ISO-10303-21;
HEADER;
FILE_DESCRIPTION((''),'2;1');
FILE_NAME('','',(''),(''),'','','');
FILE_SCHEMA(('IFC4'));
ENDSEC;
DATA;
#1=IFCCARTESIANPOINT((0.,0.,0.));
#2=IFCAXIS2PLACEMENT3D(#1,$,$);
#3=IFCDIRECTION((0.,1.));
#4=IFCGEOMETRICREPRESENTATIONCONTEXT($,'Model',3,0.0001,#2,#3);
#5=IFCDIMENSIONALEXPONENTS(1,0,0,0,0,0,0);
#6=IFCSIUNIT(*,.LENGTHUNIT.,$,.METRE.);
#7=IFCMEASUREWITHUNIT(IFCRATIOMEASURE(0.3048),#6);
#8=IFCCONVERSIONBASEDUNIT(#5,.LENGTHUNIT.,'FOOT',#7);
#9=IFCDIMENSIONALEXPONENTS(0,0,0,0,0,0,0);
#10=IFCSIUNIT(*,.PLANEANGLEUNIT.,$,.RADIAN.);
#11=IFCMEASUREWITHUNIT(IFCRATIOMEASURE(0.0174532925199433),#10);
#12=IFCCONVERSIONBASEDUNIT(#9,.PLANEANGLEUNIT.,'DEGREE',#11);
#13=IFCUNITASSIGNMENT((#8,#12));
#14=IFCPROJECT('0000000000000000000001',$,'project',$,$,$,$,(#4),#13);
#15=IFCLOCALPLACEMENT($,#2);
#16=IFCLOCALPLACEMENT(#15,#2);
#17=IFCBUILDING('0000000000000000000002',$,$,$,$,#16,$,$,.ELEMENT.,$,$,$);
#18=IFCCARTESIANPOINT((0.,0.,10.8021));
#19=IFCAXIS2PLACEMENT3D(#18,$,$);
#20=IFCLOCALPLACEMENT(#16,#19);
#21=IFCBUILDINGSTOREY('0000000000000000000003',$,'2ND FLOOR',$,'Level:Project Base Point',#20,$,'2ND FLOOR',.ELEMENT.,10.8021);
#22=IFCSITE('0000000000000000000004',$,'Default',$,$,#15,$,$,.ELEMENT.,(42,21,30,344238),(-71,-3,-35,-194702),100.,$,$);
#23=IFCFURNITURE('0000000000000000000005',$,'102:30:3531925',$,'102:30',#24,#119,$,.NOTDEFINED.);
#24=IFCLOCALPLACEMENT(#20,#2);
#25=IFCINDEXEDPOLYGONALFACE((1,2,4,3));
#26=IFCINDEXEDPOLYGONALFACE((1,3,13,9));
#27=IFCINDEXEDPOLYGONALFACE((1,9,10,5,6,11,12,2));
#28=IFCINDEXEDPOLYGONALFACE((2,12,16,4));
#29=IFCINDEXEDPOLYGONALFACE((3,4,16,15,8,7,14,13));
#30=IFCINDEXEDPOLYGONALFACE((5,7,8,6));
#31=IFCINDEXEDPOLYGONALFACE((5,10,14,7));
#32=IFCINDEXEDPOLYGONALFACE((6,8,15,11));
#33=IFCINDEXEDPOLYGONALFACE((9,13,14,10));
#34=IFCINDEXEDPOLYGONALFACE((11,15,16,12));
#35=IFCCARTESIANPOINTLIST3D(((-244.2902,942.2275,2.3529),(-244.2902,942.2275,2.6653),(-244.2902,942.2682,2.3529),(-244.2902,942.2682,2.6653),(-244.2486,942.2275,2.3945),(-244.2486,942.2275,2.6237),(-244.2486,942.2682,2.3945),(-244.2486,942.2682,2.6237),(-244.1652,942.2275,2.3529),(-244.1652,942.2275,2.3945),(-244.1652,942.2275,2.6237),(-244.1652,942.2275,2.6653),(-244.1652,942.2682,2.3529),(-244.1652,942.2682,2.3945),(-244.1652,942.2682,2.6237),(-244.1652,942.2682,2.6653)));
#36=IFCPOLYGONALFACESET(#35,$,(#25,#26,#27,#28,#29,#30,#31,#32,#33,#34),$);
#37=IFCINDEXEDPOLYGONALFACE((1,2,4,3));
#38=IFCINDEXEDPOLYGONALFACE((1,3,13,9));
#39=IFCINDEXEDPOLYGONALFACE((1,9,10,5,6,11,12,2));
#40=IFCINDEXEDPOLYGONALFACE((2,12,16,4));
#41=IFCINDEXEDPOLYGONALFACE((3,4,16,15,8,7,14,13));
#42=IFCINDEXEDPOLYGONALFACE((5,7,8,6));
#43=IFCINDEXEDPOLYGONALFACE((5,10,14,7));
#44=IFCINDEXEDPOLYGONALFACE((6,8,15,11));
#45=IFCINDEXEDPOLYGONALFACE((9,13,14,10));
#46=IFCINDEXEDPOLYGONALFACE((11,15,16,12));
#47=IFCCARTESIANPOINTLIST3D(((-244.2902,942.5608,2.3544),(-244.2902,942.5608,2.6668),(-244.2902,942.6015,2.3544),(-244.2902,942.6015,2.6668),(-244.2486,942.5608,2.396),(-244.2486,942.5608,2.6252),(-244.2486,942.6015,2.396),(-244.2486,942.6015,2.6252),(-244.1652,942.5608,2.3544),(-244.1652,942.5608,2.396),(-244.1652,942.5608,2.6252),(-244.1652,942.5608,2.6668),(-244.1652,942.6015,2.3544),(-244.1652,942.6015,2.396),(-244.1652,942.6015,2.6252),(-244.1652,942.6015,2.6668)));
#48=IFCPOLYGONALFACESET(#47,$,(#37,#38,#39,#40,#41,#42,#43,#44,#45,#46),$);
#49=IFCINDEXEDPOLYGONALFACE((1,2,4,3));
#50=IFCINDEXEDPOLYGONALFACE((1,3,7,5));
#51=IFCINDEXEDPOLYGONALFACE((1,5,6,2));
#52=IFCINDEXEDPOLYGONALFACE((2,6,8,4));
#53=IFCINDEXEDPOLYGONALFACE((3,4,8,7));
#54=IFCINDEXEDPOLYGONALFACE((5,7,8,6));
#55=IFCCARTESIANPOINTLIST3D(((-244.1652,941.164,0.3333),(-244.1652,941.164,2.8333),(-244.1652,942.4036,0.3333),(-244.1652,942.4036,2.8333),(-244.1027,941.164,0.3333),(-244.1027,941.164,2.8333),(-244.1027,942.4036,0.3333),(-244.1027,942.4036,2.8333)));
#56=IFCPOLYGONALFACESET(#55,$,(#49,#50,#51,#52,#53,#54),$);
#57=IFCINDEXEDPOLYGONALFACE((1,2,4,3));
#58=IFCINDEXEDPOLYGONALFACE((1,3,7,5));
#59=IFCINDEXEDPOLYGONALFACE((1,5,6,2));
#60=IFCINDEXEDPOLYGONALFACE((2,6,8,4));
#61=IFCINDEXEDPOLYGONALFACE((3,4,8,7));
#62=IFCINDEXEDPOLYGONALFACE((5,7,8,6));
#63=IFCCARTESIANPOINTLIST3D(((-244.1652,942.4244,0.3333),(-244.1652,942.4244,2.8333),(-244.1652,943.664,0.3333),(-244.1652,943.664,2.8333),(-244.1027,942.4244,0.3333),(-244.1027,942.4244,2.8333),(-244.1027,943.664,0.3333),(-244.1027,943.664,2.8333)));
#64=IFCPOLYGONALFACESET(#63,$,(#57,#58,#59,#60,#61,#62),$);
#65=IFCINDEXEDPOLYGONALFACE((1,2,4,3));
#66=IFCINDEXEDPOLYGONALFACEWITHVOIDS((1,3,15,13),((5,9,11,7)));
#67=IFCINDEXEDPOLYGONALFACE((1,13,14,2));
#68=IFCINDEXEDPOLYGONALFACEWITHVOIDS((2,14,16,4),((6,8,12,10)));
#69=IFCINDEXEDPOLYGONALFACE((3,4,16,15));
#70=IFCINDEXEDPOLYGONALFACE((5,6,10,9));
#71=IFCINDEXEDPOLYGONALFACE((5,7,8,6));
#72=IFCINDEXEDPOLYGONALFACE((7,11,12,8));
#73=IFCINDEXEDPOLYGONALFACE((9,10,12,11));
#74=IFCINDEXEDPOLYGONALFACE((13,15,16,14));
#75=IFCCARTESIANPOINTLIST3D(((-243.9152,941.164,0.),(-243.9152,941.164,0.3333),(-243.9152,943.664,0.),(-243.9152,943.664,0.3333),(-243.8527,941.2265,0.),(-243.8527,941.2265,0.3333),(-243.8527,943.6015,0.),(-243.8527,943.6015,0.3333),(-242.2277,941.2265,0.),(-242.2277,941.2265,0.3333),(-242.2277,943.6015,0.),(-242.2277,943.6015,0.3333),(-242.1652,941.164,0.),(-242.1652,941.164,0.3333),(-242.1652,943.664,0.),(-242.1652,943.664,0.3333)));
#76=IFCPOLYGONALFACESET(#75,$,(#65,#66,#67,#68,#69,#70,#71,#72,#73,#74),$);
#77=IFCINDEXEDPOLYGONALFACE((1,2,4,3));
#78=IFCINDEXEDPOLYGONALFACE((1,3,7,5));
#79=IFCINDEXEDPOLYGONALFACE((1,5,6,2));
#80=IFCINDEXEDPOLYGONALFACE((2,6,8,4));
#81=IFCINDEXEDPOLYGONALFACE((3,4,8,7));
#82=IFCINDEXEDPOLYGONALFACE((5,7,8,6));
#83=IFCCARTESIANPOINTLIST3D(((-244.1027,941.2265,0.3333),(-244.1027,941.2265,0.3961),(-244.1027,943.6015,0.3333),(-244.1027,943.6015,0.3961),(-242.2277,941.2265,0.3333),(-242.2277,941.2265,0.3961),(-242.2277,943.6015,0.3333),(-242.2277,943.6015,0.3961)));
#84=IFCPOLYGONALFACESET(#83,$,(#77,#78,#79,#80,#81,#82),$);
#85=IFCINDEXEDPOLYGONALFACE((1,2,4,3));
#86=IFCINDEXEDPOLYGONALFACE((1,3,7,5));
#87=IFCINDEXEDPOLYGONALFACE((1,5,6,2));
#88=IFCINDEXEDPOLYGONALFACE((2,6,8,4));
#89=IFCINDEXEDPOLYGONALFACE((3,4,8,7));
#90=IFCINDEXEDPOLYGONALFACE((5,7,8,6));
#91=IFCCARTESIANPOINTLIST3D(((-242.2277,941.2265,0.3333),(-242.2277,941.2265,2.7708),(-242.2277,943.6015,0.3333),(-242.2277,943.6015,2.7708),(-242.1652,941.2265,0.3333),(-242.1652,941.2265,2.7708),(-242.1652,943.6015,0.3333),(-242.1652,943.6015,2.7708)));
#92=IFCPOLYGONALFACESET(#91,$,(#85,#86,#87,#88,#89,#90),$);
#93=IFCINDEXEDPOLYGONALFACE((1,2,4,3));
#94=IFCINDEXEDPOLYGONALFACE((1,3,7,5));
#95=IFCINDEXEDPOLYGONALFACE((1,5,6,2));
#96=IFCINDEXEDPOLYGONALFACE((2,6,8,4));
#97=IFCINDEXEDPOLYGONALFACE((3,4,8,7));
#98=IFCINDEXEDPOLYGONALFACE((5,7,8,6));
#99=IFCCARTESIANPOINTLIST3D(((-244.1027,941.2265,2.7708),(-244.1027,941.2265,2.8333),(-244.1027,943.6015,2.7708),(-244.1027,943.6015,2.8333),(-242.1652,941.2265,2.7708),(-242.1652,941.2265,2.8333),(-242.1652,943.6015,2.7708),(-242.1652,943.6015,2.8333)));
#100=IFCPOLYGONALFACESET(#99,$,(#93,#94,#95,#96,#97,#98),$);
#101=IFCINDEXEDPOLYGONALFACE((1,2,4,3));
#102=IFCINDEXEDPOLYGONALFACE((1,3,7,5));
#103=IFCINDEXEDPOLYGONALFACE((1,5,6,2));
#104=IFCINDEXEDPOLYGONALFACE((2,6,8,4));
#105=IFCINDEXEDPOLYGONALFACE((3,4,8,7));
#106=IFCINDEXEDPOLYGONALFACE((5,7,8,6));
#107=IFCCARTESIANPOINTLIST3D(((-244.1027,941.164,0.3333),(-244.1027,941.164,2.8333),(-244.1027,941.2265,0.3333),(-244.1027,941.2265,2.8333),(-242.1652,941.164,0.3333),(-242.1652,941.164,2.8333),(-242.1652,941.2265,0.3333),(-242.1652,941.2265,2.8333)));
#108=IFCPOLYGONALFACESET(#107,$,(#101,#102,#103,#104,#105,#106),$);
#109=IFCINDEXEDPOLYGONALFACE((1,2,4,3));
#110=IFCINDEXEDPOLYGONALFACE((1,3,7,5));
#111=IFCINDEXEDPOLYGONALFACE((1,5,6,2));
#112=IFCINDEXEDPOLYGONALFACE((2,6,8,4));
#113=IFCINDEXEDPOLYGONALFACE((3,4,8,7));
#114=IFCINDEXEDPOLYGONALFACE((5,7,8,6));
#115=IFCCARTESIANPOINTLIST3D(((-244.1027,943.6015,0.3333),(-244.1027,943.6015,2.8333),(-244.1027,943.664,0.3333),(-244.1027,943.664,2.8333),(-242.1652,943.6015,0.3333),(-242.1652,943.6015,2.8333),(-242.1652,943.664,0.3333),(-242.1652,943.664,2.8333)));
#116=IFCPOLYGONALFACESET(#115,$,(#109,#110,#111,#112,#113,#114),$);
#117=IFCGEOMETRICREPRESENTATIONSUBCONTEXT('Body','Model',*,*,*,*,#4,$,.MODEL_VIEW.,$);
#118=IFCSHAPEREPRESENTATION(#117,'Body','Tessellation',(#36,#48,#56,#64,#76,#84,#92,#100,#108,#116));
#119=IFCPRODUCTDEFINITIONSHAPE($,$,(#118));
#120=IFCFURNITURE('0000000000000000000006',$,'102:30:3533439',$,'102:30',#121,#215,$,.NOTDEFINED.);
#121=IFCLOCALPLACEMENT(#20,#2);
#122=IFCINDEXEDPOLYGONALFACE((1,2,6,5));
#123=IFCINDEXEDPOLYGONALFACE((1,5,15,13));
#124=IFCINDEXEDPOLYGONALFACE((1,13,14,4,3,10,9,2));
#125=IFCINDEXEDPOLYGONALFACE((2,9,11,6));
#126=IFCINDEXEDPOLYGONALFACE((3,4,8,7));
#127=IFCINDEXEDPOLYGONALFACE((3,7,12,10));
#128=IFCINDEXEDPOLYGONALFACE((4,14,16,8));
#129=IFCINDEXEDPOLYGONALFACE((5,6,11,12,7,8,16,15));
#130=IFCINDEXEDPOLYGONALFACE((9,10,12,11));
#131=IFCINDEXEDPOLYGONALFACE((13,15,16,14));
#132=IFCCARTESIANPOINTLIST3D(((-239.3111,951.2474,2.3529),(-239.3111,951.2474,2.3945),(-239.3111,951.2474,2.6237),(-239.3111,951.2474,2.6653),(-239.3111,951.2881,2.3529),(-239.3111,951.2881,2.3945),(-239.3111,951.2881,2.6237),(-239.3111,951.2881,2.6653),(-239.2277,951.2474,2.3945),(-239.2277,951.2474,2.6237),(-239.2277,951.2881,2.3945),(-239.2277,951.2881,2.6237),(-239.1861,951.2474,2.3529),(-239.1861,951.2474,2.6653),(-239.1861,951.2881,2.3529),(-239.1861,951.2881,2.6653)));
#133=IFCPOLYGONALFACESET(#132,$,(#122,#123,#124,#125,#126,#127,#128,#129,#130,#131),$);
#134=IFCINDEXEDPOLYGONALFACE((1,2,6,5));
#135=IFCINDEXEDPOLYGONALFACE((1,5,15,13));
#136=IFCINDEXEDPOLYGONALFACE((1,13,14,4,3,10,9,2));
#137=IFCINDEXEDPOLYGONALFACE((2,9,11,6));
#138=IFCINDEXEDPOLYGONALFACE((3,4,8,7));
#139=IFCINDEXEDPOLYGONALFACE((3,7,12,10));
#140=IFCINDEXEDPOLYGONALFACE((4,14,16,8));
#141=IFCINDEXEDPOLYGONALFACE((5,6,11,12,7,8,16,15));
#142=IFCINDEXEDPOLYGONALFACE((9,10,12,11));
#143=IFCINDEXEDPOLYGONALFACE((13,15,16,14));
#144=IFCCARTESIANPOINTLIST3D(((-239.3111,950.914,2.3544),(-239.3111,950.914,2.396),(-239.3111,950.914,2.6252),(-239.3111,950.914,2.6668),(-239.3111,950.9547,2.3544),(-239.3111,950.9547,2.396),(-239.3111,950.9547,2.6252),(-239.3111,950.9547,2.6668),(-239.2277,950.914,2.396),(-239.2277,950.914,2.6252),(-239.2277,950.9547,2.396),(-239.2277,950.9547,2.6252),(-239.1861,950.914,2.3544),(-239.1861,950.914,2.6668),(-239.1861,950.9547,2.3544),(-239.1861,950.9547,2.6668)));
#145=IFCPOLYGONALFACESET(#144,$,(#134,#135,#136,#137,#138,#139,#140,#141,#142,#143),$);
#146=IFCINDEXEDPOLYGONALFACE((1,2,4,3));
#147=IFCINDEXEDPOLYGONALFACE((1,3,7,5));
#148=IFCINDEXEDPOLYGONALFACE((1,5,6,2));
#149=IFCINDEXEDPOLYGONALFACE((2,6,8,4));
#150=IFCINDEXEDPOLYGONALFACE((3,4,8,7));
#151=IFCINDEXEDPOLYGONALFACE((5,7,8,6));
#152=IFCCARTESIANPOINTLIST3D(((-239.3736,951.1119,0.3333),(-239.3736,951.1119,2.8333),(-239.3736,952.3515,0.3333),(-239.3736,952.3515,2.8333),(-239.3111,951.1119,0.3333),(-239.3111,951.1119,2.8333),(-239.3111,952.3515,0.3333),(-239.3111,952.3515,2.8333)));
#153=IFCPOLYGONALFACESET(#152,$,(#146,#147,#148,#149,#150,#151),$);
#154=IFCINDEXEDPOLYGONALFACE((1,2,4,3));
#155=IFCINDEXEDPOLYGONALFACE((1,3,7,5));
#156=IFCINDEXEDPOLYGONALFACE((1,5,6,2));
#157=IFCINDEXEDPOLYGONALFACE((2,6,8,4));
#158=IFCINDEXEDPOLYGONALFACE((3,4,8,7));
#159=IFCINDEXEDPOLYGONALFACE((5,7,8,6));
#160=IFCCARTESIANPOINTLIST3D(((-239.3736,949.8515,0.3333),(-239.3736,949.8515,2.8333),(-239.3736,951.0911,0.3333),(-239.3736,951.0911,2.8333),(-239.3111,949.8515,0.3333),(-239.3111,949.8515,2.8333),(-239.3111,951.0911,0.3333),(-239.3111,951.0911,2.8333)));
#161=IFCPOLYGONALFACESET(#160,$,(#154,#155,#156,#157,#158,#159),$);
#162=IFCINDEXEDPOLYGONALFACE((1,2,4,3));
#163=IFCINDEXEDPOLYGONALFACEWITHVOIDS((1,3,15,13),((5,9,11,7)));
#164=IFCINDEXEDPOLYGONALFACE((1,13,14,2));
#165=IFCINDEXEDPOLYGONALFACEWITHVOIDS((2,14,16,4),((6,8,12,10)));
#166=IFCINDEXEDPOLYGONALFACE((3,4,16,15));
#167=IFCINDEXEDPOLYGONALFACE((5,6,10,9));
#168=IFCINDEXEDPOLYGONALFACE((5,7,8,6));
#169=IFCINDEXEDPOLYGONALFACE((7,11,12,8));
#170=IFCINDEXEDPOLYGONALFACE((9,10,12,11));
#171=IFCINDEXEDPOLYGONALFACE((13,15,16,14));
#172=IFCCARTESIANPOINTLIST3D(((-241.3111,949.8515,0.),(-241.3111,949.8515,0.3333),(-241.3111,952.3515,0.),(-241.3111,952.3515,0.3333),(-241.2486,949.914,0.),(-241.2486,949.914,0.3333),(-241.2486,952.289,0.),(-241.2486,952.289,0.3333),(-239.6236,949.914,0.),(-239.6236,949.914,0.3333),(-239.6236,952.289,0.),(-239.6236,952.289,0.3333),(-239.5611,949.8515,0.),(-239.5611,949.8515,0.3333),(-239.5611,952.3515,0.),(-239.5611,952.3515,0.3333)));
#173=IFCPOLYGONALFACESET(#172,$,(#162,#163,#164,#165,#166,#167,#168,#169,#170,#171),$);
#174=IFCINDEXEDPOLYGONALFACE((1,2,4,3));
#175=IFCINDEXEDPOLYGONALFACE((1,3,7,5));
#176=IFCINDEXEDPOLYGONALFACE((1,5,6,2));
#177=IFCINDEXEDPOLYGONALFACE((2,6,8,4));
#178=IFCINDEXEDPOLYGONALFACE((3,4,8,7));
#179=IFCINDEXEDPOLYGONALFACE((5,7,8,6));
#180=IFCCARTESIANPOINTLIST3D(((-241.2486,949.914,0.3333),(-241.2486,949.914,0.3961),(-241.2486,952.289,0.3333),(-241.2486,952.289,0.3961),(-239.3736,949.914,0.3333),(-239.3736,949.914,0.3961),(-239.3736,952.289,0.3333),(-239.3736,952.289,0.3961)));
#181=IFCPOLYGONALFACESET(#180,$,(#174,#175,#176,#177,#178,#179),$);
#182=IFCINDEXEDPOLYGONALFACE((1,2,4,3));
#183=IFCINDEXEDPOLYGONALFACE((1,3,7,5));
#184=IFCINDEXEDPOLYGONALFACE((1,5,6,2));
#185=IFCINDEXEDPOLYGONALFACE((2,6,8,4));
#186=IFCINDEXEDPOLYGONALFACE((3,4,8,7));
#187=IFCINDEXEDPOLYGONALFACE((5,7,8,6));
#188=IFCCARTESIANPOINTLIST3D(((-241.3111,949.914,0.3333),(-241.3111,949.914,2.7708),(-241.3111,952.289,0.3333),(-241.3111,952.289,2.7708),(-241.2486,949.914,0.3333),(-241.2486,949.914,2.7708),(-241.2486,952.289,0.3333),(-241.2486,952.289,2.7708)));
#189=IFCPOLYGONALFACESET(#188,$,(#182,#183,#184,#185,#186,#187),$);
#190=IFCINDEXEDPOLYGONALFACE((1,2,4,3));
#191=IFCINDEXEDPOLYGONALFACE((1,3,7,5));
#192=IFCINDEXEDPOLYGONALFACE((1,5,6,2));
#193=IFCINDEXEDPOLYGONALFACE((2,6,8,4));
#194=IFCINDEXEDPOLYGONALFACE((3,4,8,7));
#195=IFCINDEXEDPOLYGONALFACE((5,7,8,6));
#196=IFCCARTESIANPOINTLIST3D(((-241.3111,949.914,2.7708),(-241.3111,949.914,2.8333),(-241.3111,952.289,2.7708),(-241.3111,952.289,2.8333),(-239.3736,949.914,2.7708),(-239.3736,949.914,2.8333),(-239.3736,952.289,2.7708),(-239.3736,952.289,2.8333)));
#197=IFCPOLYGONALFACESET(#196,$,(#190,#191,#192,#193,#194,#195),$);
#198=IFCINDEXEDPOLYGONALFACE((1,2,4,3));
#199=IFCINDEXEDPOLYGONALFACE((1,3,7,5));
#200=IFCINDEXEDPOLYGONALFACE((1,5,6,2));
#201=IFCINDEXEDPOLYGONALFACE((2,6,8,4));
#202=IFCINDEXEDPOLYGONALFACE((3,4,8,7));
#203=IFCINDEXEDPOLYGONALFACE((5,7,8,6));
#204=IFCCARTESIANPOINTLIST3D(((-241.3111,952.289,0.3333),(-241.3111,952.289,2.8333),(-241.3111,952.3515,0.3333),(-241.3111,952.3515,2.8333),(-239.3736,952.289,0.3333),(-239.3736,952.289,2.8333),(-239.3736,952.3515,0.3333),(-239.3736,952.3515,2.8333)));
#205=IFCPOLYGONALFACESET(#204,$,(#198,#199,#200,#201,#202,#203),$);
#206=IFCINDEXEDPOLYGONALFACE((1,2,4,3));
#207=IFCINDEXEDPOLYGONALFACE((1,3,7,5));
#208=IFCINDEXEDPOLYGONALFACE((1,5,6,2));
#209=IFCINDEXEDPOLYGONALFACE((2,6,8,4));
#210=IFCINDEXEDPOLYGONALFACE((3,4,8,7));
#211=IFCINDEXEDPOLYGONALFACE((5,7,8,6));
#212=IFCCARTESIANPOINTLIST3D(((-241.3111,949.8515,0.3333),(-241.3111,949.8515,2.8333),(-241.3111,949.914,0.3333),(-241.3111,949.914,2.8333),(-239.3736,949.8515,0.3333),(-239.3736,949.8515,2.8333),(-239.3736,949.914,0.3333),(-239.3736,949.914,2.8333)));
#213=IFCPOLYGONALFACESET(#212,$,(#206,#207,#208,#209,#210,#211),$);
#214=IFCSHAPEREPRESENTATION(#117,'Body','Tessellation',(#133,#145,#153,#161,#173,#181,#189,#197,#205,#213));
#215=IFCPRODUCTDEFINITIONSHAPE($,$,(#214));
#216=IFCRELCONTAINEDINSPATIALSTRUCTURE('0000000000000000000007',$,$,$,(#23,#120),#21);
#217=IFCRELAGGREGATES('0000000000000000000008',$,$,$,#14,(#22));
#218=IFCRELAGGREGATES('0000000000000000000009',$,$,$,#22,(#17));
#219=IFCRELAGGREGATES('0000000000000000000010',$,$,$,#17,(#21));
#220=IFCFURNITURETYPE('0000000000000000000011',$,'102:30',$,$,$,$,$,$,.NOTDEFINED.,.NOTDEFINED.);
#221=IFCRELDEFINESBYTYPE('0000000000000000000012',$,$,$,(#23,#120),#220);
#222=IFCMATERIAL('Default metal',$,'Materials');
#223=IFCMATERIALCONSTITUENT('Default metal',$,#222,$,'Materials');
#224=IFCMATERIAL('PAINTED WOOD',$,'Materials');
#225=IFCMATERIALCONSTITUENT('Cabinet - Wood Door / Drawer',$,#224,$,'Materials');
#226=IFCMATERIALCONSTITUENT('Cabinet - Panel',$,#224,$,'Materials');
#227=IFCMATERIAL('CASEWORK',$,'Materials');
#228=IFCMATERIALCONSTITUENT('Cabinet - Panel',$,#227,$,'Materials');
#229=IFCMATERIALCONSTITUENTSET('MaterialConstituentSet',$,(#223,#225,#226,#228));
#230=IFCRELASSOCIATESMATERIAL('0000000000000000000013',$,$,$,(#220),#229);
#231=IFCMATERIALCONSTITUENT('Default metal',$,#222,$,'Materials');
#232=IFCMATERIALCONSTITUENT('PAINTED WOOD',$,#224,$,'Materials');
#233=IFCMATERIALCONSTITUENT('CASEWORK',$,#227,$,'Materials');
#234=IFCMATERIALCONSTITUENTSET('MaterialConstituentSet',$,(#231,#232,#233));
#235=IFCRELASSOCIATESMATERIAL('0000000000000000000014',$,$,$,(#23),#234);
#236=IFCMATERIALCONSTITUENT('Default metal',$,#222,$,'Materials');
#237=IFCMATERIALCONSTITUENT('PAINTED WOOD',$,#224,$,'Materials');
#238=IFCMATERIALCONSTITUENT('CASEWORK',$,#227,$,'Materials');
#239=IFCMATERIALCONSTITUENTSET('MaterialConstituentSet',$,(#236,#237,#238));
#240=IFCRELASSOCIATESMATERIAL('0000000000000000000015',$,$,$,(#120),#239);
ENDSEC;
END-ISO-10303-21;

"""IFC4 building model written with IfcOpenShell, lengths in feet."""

from ifc_helpers import new_model, entity, si_unit, converted_unit, direction, frame, frame_2d, origin, origin_2d_with_axis, place, context, subcontext, project, spatial, polyline, rectangle, outline, extrude, source, transform, mapped, material, constituent, constituent_set, type_object, type_shapes, element, save


model = new_model("IFC4")

# Units and contexts
model_context = context("Model", 3, precision=0.0001, world=origin(), true_north=direction((0.0, 1.0)))
body_context = subcontext(model_context, "Body", "Model", "MODEL_VIEW")
ifc_project = project(units=[converted_unit("LENGTHUNIT", "FOOT", entity("IfcRatioMeasure", 0.3048), si_unit("LENGTHUNIT", "METRE"), dimensions=[1, 0, 0, 0, 0, 0, 0]), converted_unit("PLANEANGLEUNIT", "DEGREE", entity("IfcRatioMeasure", 0.0174532925199433), si_unit("PLANEANGLEUNIT", "RADIAN"), dimensions=[0, 0, 0, 0, 0, 0, 0])], contexts=[model_context])

# Site, building, storey
site_placement = place(None, origin())
site = spatial("IfcSite", under=ifc_project, at=site_placement, Name="Default", CompositionType="ELEMENT", RefLatitude=(42, 21, 30, 344238), RefLongitude=(-71, -3, -35, -194702), RefElevation=100.0)
building_placement = place(site_placement, origin())
building = spatial("IfcBuilding", under=site, at=building_placement, CompositionType="ELEMENT")
storey_placement = place(building_placement, frame((0.0, 0.0, 10.8021)))
storey = spatial("IfcBuildingStorey", under=building, at=storey_placement, Name="2ND FLOOR", ObjectType="Level:Project Base Point", LongName="2ND FLOOR", CompositionType="ELEMENT", Elevation=10.8021)

# Shared definitions
ifc_material_1 = material(Name="Default metal", Category="Materials")
ifc_material_2 = material(Name="PAINTED WOOD", Category="Materials")
ifc_material_3 = material(Name="CASEWORK", Category="Materials")

# Furniture
ifc_constituent_1 = constituent(ifc_material_1, Name="Default metal", Category="Materials")
ifc_constituent_2 = constituent(ifc_material_2, Name="PAINTED WOOD", Category="Materials")
ifc_constituent_3 = constituent(ifc_material_3, Name="CASEWORK", Category="Materials")
ifc_constituent_set_1 = constituent_set(constituents=[ifc_constituent_1, ifc_constituent_2, ifc_constituent_3], Name="MaterialConstituentSet")
ifc_constituent_4 = constituent(ifc_material_1, Name="Default metal", Category="Materials")
ifc_constituent_5 = constituent(ifc_material_2, Name="Cabinet - Wood Door / Drawer", Category="Materials")
ifc_constituent_6 = constituent(ifc_material_2, Name="Cabinet - Panel", Category="Materials")
ifc_constituent_7 = constituent(ifc_material_3, Name="Cabinet - Panel", Category="Materials")
ifc_constituent_set_2 = constituent_set(constituents=[ifc_constituent_4, ifc_constituent_5, ifc_constituent_6, ifc_constituent_7], Name="MaterialConstituentSet")
furniture_type_1 = type_object("IfcFurnitureType", Name="102:30", AssemblyPlace="NOTDEFINED", PredefinedType="NOTDEFINED", material=ifc_constituent_set_2)
shared_shape_1 = source(origin(), body_context, "Body", "SweptSolid", [
    extrude(outline(polyline([(0.1146, -0.0521), (0.1562, -0.0521), (0.1562, 0.0729), (-0.1562, 0.0729), (-0.1562, -0.0521), (-0.1146, -0.0521), (-0.1146, 0.0313), (0.1146, 0.0313), (0.1146, -0.0521)])), frame((0.2073, -2.0521, 2.5091), z_axis=(1.0, 0.0, 0.0), x_axis=(0.0, 0.0, 1.0)), (0.0, 0.0, 1.0), 0.0407),
    extrude(outline(polyline([(0.1146, -0.0521), (0.1562, -0.0521), (0.1562, 0.0729), (-0.1562, 0.0729), (-0.1562, -0.0521), (-0.1146, -0.0521), (-0.1146, 0.0313), (0.1146, 0.0313), (0.1146, -0.0521)])), frame((-0.126, -2.0521, 2.5106), z_axis=(1.0, 0.0, 0.0), x_axis=(0.0, 0.0, 1.0)), (0.0, 0.0, 1.0), 0.0407),
    extrude(rectangle(XDim=0.0625, YDim=1.2396, at=frame_2d((0.0, 0.0), x_axis=(1.0, 0.0))), frame((0.6917, -1.9688, 0.3333), z_axis=(0.0, 0.0, 1.0), x_axis=(0.0, 1.0, 0.0)), (0.0, 0.0, 1.0), 2.5),
    extrude(rectangle(XDim=0.0625, YDim=1.2396, at=origin_2d_with_axis()), frame((-0.5687, -1.9688, 0.3333), z_axis=(0.0, 0.0, 1.0), x_axis=(0.0, 1.0, 0.0)), (0.0, 0.0, 1.0), 2.5),
    extrude(outline(polyline([(-1.25, -0.875), (1.25, -0.875), (1.25, 0.875), (-1.25, 0.875), (-1.25, -0.875)]), holes=[polyline([(-1.1875, -0.8125), (-1.1875, 0.8125), (1.1875, 0.8125), (1.1875, -0.8125), (-1.1875, -0.8125)])]), frame((0.0615, -0.875, 0.0)), (0.0, 0.0, 1.0), 0.3333),
    extrude(rectangle(XDim=2.375, YDim=1.875, at=frame_2d((0.0, 0.0), x_axis=(1.0, 0.0))), frame((0.0615, -1.0, 0.3333), z_axis=(0.0, 0.0, 1.0), x_axis=(-1.0, 0.0, 0.0)), (0.0, 0.0, 1.0), 0.0627),
    extrude(rectangle(XDim=0.0625, YDim=2.375, at=origin_2d_with_axis()), frame((0.0615, -0.0312, 0.3333), z_axis=(0.0, 0.0, 1.0), x_axis=(0.0, 1.0, 0.0)), (0.0, 0.0, 1.0), 2.4375),
    extrude(rectangle(XDim=2.375, YDim=1.9375, at=origin_2d_with_axis()), frame((0.0615, -0.9688, 2.7708), z_axis=(0.0, 0.0, 1.0), x_axis=(-1.0, 0.0, 0.0)), (0.0, 0.0, 1.0), 0.0625),
    extrude(rectangle(XDim=0.0625, YDim=1.9375, at=frame_2d((0.0, 0.0), x_axis=(1.0, 0.0))), frame((1.2802, -0.9687, 0.3333)), (0.0, 0.0, 1.0), 2.5),
    extrude(rectangle(XDim=0.0625, YDim=1.9375, at=frame_2d((0.0, 0.0), x_axis=(1.0, 0.0))), frame((-1.1573, -0.9687, 0.3333)), (0.0, 0.0, 1.0), 2.5),
])
type_shapes(furniture_type_1, [shared_shape_1])
furniture_1_placement = place(storey_placement, frame((-242.1652, 942.4755, 0.0), z_axis=(0.0, 0.0, 1.0), x_axis=(0.0, -1.0, 0.0)))
element("IfcFurniture", 1, at=furniture_1_placement, inside=storey, type_object=furniture_type_1, material=ifc_constituent_set_1, Name="102:30:3531925", ObjectType="102:30", PredefinedType="NOTDEFINED", context=body_context, shape_type="MappedRepresentation", body=[
    mapped(shared_shape_1, transform((0.0, 0.0, 0.0), scale=1.0)),
])
ifc_constituent_8 = constituent(ifc_material_1, Name="Default metal", Category="Materials")
ifc_constituent_9 = constituent(ifc_material_2, Name="PAINTED WOOD", Category="Materials")
ifc_constituent_10 = constituent(ifc_material_3, Name="CASEWORK", Category="Materials")
ifc_constituent_set_3 = constituent_set(constituents=[ifc_constituent_8, ifc_constituent_9, ifc_constituent_10], Name="MaterialConstituentSet")
furniture_2_placement = place(storey_placement, frame((-241.3111, 951.04, 0.0), z_axis=(0.0, 0.0, 1.0), x_axis=(0.0, 1.0, 0.0)))
element("IfcFurniture", 2, at=furniture_2_placement, inside=storey, type_object=furniture_type_1, material=ifc_constituent_set_3, Name="102:30:3533439", ObjectType="102:30", PredefinedType="NOTDEFINED", context=body_context, shape_type="MappedRepresentation", body=[
    mapped(shared_shape_1, transform((0.0, 0.0, 0.0), scale=1.0)),
])

save(model, "model.ifc")
